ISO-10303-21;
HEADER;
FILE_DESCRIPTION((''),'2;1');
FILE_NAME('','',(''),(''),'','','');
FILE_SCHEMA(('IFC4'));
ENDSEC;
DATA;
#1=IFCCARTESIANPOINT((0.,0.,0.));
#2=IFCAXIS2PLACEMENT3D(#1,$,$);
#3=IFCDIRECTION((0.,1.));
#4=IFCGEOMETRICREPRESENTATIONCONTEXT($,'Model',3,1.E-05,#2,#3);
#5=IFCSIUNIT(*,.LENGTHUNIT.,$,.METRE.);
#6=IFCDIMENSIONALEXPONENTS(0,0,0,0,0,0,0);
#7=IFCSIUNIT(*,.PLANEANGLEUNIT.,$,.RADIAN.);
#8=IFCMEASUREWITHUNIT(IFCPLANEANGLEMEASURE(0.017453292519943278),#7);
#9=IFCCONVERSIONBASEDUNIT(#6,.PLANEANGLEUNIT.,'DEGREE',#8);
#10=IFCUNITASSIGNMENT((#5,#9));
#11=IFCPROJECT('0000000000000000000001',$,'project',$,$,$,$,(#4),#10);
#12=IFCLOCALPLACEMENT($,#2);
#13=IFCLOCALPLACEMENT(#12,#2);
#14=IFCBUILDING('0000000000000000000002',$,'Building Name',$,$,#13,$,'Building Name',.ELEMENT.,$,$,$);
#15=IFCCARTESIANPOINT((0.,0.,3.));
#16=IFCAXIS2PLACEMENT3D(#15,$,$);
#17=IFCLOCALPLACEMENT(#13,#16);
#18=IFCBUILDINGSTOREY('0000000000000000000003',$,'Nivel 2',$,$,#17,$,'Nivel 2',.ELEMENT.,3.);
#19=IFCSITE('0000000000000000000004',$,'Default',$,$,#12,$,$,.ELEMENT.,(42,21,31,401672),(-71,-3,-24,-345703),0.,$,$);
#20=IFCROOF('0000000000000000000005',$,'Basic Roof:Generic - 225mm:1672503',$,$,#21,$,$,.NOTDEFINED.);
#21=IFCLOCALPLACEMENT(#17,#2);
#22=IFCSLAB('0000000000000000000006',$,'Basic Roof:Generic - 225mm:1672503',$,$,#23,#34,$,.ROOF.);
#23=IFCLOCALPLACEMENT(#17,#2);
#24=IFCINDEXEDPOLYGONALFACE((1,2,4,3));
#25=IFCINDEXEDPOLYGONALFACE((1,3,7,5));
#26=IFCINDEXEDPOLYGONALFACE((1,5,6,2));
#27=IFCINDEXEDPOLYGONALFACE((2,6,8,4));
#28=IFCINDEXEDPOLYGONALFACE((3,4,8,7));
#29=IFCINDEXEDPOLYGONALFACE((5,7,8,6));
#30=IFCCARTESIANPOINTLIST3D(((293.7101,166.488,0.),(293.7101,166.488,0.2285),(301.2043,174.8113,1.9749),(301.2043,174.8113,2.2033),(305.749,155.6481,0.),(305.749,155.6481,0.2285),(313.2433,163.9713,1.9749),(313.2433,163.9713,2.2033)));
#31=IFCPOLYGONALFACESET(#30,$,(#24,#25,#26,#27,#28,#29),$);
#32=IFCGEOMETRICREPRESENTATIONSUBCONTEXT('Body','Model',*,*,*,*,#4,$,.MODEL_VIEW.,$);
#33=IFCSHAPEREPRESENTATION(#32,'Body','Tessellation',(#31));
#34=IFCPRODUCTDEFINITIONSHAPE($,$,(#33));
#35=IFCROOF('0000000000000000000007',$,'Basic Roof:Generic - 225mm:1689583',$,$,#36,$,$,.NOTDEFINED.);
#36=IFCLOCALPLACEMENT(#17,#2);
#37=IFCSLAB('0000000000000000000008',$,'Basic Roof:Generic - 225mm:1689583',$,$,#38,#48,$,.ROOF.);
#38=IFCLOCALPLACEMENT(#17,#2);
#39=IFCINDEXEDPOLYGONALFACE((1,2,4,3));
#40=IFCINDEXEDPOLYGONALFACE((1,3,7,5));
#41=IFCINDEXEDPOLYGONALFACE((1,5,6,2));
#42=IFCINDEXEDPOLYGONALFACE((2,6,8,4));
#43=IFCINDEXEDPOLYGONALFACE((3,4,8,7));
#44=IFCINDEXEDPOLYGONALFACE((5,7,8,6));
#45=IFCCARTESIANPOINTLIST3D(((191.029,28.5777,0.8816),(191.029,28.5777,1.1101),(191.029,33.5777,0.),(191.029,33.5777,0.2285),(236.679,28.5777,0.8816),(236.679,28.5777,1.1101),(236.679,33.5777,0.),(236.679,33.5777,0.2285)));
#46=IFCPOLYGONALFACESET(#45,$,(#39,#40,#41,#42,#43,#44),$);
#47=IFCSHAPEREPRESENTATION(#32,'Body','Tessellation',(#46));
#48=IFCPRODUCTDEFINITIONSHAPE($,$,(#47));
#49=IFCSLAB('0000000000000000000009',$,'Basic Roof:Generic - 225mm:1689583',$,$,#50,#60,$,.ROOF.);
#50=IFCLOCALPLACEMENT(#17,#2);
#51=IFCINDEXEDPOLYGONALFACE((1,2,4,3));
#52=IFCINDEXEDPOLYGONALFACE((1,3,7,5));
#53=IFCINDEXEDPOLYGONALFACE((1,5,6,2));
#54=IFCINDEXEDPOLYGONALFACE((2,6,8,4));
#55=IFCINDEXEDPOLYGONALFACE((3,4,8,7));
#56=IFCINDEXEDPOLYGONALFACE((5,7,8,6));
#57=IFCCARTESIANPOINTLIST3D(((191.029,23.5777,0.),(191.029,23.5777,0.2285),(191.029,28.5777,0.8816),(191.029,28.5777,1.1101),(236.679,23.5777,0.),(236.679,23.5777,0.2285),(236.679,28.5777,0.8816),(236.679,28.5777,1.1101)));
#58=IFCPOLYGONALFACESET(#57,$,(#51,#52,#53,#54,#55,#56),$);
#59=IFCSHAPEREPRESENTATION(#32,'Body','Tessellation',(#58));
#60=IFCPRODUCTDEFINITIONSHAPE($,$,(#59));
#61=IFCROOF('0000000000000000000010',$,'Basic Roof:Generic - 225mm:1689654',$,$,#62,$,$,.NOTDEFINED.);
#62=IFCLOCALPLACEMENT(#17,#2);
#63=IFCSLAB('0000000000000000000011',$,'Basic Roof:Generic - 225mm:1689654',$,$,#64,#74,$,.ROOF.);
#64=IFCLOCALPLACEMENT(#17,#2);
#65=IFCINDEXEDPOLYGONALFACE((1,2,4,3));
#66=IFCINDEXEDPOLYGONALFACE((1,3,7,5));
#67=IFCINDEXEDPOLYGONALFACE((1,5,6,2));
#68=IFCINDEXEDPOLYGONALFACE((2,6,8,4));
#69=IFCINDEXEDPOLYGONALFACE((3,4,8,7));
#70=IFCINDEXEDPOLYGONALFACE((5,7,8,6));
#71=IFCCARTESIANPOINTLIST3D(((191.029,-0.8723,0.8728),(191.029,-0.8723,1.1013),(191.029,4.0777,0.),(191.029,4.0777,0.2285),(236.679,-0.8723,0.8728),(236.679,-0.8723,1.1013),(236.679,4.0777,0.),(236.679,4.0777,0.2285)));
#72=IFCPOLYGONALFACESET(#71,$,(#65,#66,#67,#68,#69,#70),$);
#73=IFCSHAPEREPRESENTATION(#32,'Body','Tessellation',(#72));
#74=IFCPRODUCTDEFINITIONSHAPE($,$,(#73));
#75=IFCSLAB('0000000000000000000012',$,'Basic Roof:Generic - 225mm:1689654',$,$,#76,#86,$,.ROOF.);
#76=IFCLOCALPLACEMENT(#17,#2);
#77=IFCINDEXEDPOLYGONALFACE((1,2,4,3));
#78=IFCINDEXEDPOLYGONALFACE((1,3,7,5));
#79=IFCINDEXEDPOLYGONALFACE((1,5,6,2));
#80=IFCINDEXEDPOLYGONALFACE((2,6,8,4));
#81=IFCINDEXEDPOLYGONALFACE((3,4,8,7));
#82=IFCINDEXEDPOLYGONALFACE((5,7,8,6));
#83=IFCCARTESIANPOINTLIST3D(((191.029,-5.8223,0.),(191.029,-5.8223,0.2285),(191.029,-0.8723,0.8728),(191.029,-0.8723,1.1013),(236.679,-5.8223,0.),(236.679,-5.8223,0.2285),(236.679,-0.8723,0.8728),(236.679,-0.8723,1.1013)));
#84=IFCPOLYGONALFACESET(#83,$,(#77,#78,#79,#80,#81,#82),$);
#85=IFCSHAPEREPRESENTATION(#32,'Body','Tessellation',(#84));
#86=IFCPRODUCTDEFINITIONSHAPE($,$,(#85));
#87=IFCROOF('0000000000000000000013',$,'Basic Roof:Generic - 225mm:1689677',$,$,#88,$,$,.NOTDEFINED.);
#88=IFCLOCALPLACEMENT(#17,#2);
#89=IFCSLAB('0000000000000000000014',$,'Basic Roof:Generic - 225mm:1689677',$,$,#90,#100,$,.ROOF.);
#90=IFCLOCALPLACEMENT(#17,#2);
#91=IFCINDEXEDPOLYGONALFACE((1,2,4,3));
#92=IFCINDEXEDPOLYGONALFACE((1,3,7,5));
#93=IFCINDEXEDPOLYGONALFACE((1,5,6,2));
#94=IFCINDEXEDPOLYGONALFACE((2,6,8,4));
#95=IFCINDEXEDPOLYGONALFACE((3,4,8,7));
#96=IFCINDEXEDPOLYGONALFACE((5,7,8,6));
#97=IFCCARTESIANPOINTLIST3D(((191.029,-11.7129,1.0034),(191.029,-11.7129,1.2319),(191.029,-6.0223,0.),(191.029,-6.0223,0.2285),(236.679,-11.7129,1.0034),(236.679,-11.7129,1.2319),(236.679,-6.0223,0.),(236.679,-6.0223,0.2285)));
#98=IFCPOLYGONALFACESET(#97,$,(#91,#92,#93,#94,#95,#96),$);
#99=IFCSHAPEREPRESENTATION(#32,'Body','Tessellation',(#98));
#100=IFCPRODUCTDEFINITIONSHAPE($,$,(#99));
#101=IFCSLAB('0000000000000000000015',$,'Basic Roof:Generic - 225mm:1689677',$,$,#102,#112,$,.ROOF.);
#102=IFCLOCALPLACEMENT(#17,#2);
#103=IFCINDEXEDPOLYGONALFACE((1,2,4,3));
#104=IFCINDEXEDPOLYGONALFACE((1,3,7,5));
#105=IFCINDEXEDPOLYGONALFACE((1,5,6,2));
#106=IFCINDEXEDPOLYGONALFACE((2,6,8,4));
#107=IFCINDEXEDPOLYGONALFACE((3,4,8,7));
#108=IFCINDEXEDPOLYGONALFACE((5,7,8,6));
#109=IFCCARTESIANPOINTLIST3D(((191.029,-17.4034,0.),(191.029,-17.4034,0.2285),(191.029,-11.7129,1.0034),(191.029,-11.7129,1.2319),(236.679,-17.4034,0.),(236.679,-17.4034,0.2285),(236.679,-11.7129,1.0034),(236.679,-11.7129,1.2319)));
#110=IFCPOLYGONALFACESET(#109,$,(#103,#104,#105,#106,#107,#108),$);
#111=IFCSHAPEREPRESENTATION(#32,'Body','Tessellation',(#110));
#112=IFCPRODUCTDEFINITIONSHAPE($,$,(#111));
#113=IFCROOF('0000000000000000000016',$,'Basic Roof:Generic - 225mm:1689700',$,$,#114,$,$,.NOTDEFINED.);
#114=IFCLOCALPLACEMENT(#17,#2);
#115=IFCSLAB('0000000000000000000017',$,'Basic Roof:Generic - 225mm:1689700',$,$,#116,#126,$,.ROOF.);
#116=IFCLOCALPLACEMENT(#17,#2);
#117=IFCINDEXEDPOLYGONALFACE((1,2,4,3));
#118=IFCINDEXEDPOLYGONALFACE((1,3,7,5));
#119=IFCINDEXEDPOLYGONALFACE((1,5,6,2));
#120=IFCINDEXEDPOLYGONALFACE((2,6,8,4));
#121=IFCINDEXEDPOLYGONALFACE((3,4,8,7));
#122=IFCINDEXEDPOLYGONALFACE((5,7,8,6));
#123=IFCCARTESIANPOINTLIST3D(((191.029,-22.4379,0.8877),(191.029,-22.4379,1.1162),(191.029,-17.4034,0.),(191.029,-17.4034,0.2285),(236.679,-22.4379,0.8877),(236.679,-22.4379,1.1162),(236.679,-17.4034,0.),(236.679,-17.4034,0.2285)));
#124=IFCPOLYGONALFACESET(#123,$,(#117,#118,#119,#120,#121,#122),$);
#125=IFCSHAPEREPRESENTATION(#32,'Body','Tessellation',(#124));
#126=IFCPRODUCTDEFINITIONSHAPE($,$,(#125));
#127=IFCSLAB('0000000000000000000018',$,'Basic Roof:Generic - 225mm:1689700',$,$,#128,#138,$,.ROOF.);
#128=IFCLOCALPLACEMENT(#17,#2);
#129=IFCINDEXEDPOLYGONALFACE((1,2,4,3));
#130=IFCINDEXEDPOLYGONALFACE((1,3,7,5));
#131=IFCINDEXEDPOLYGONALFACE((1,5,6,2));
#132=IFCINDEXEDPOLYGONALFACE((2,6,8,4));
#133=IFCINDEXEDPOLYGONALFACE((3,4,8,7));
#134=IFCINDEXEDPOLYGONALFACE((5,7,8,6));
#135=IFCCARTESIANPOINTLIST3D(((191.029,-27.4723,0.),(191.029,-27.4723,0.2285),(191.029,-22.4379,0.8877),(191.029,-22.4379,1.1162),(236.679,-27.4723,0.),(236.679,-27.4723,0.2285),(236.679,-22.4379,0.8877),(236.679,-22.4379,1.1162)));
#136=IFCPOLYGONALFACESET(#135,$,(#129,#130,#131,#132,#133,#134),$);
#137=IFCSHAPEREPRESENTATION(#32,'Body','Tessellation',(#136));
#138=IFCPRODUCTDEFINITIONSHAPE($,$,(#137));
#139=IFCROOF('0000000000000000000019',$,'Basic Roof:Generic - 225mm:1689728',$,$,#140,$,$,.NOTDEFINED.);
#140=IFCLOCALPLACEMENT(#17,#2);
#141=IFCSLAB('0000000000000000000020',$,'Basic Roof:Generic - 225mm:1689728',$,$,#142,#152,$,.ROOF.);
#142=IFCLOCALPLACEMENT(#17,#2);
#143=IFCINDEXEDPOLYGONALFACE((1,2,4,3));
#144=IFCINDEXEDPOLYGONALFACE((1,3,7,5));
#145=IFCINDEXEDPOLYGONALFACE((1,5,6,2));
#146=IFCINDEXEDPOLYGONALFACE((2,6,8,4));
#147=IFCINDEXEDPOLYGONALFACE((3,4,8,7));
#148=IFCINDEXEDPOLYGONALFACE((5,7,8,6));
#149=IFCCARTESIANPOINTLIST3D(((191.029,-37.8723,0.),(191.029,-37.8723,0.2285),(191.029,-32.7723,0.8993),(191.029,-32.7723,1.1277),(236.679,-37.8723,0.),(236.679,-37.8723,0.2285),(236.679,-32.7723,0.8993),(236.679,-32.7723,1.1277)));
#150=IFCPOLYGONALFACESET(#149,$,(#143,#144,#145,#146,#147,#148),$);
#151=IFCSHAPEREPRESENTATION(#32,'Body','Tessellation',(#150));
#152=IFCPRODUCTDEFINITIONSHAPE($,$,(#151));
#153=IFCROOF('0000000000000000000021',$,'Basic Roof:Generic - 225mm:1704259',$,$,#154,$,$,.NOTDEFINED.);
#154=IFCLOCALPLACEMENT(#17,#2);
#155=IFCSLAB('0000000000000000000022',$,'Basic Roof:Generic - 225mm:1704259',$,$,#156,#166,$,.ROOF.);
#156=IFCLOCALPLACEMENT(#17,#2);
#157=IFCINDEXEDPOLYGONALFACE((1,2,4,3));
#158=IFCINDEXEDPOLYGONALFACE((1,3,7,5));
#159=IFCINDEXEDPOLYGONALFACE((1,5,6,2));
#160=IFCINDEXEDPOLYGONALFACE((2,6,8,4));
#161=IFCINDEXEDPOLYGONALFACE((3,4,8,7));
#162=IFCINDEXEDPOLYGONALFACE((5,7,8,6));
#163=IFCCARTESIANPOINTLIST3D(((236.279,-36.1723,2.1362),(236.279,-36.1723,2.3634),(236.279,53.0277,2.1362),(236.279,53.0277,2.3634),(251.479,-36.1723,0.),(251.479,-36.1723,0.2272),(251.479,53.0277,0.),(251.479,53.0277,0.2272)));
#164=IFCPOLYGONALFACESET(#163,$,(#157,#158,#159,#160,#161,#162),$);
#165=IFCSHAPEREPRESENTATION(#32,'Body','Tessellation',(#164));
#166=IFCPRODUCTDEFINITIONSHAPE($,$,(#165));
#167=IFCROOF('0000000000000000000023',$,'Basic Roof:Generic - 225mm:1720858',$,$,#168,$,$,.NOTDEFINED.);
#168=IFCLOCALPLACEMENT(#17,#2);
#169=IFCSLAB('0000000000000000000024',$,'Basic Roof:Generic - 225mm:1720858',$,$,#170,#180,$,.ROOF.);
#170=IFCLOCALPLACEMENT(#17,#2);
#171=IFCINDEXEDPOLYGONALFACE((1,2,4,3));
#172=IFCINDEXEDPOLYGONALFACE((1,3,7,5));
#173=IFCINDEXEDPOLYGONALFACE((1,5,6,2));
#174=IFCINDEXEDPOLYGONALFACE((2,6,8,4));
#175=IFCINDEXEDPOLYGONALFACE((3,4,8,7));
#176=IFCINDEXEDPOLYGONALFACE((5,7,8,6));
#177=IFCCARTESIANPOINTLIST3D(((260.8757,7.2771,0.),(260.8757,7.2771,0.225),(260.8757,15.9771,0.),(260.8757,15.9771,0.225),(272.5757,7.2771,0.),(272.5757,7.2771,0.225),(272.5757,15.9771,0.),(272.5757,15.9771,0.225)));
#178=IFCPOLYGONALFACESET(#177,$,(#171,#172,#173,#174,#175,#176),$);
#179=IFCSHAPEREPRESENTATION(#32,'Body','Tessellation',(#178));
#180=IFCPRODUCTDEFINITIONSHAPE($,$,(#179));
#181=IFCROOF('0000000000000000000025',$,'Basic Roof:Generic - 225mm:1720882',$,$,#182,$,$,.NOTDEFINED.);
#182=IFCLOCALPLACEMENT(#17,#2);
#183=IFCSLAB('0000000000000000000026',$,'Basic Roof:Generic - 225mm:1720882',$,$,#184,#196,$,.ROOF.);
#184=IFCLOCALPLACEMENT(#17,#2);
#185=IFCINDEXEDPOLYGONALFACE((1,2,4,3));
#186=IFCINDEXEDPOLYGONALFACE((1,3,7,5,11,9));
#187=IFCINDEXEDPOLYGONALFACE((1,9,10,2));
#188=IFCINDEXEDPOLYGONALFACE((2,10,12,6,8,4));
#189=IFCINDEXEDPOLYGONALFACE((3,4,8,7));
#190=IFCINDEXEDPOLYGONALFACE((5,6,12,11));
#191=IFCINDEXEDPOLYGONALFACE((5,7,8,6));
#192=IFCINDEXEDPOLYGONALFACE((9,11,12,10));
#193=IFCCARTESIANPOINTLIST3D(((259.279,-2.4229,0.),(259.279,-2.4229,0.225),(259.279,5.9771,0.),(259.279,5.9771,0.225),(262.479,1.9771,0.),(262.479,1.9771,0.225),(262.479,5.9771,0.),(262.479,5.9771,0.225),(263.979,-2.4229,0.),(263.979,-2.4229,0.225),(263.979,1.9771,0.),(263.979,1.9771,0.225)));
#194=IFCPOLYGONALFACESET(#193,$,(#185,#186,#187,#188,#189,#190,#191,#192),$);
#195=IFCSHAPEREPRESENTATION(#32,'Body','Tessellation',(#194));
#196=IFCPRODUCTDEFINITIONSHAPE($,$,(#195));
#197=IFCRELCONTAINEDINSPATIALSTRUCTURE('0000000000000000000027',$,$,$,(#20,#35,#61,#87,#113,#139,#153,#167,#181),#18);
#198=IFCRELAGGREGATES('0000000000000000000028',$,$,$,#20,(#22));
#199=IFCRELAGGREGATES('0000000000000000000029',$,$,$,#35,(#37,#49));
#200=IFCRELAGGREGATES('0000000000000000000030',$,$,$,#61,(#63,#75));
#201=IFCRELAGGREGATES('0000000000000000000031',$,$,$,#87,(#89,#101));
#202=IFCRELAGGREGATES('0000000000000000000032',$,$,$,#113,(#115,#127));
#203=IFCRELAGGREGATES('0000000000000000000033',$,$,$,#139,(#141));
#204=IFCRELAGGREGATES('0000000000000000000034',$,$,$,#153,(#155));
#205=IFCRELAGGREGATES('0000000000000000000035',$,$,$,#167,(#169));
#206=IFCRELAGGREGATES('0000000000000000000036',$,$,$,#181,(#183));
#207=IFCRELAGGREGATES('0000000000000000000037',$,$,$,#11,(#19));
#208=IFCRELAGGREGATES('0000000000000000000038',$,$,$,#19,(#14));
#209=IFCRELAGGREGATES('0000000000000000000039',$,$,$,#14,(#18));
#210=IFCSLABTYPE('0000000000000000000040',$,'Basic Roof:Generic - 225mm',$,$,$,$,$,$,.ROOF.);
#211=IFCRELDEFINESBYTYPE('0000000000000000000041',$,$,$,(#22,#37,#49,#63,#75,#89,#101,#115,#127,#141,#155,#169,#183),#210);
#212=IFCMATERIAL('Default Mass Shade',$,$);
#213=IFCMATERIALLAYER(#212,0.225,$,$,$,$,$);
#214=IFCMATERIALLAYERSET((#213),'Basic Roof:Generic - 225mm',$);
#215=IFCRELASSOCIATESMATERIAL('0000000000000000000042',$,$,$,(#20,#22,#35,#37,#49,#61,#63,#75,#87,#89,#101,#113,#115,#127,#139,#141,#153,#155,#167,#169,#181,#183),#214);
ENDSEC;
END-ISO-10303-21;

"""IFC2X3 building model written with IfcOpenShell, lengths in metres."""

from ifc_helpers import new_model, entity, si_unit, converted_unit, direction, frame, frame_2d, origin, place, context, subcontext, project, spatial, polyline, rectangle, outline, extrude, material, layer, layer_set, type_object, element, aggregate, save


model = new_model("IFC2X3")

# Units and contexts
model_context = context("Model", 3, precision=1e-05, world=origin(), true_north=direction((0.0, 1.0)))
body_context = subcontext(model_context, "Body", "Model", "MODEL_VIEW")
ifc_project = project(units=[si_unit("LENGTHUNIT", "METRE"), converted_unit("PLANEANGLEUNIT", "DEGREE", entity("IfcPlaneAngleMeasure", 0.017453292519943278), si_unit("PLANEANGLEUNIT", "RADIAN"), dimensions=[0, 0, 0, 0, 0, 0, 0])], contexts=[model_context])

# Site, building, storey
site_placement = place(None, origin())
site = spatial("IfcSite", under=ifc_project, at=site_placement, Name="Default", CompositionType="ELEMENT", RefLatitude=(42, 21, 31, 401672), RefLongitude=(-71, -3, -24, -345703), RefElevation=0.0)
building_placement = place(site_placement, origin())
building = spatial("IfcBuilding", under=site, at=building_placement, Name="Building Name", LongName="Building Name", CompositionType="ELEMENT")
storey_placement = place(building_placement, frame((0.0, 0.0, 3.0)))
storey = spatial("IfcBuildingStorey", under=building, at=storey_placement, Name="Nivel 2", LongName="Nivel 2", CompositionType="ELEMENT", Elevation=3.0)

# Roof, slab
ifc_material_1 = material(Name="Default Mass Shade")
ifc_layer_1 = layer(ifc_material_1, 0.225)
ifc_layer_set_1 = layer_set([ifc_layer_1], Name="Basic Roof:Generic - 225mm")
roof_1_placement = place(storey_placement, frame((293.7101, 155.6481, 0.0)))
roof_1 = element("IfcRoof", 1, at=roof_1_placement, inside=storey, material=ifc_layer_set_1, Name="Basic Roof:Generic - 225mm:1672503", ShapeType="NOTDEFINED")
slab_type = type_object("IfcSlabType", Name="Basic Roof:Generic - 225mm", PredefinedType="ROOF")
slab_1_placement = place(roof_1_placement, origin())
slab_1 = element("IfcSlab", 2, at=slab_1_placement, type_object=slab_type, material=ifc_layer_set_1, Name="Basic Roof:Generic - 225mm:1672503", PredefinedType="ROOF", context=body_context, shape_type="SweptSolid", body=[
    extrude(rectangle(XDim=16.2, YDim=11.3728, at=frame_2d((0.0, 0.0), x_axis=(-0.748213, 0.663459))), frame((9.7666, 9.5816, 0.9874), z_axis=(-0.116193, -0.129046, 0.984808), x_axis=(0.993227, -0.015097, 0.115208)), (0.115208, 0.129926, 0.984808), 0.2285),
])
aggregate(roof_1, [slab_1])

# Roofs, slabs
roof_2_placement = place(storey_placement, frame((191.029, 23.5777, 0.0)))
roof_2 = element("IfcRoof", 3, at=roof_2_placement, inside=storey, material=ifc_layer_set_1, Name="Basic Roof:Generic - 225mm:1689583", ShapeType="NOTDEFINED")
slab_2_placement = place(roof_2_placement, origin())
slab_2 = element("IfcSlab", 4, at=slab_2_placement, type_object=slab_type, material=ifc_layer_set_1, Name="Basic Roof:Generic - 225mm:1689583", PredefinedType="ROOF", context=body_context, shape_type="SweptSolid", body=[
    extrude(rectangle(XDim=45.65, YDim=5.0771, at=frame_2d((0.0, 0.0), x_axis=(1.0, 0.0))), frame((22.825, 7.5, 0.4408), z_axis=(0.0, 0.173648, 0.984808), x_axis=(1.0, 0.0, 0.0)), (0.0, -0.173648, 0.984808), 0.2285),
])
slab_3_placement = place(roof_2_placement, origin())
slab_3 = element("IfcSlab", 5, at=slab_3_placement, type_object=slab_type, material=ifc_layer_set_1, Name="Basic Roof:Generic - 225mm:1689583", PredefinedType="ROOF", context=body_context, shape_type="SweptSolid", body=[
    extrude(rectangle(XDim=5.0771, YDim=45.65, at=frame_2d((0.0, 0.0), x_axis=(0.0, 1.0))), frame((22.825, 2.5, 0.4408), z_axis=(0.0, -0.173648, 0.984808), x_axis=(1.0, 0.0, 0.0)), (0.0, 0.173648, 0.984808), 0.2285),
])
aggregate(roof_2, [slab_2, slab_3])
roof_3_placement = place(storey_placement, frame((191.029, -5.8223, 0.0)))
roof_3 = element("IfcRoof", 6, at=roof_3_placement, inside=storey, material=ifc_layer_set_1, Name="Basic Roof:Generic - 225mm:1689654", ShapeType="NOTDEFINED")
slab_4_placement = place(roof_3_placement, origin())
slab_4 = element("IfcSlab", 7, at=slab_4_placement, type_object=slab_type, material=ifc_layer_set_1, Name="Basic Roof:Generic - 225mm:1689654", PredefinedType="ROOF", context=body_context, shape_type="SweptSolid", body=[
    extrude(rectangle(XDim=45.65, YDim=5.0264, at=frame_2d((0.0, 0.0), x_axis=(1.0, 0.0))), frame((22.825, 7.425, 0.4364), z_axis=(0.0, 0.173648, 0.984808), x_axis=(1.0, 0.0, 0.0)), (0.0, -0.173648, 0.984808), 0.2285),
])
slab_5_placement = place(roof_3_placement, origin())
slab_5 = element("IfcSlab", 8, at=slab_5_placement, type_object=slab_type, material=ifc_layer_set_1, Name="Basic Roof:Generic - 225mm:1689654", PredefinedType="ROOF", context=body_context, shape_type="SweptSolid", body=[
    extrude(rectangle(XDim=5.0264, YDim=45.65, at=frame_2d((0.0, 0.0), x_axis=(0.0, 1.0))), frame((22.825, 2.475, 0.4364), z_axis=(0.0, -0.173648, 0.984808), x_axis=(1.0, 0.0, 0.0)), (0.0, 0.173648, 0.984808), 0.2285),
])
aggregate(roof_3, [slab_4, slab_5])
roof_4_placement = place(storey_placement, frame((191.029, -17.4034, 0.0)))
roof_4 = element("IfcRoof", 9, at=roof_4_placement, inside=storey, material=ifc_layer_set_1, Name="Basic Roof:Generic - 225mm:1689677", ShapeType="NOTDEFINED")
slab_6_placement = place(roof_4_placement, origin())
slab_6 = element("IfcSlab", 10, at=slab_6_placement, type_object=slab_type, material=ifc_layer_set_1, Name="Basic Roof:Generic - 225mm:1689677", PredefinedType="ROOF", context=body_context, shape_type="SweptSolid", body=[
    extrude(rectangle(XDim=45.65, YDim=5.7783, at=frame_2d((0.0, 0.0), x_axis=(1.0, 0.0))), frame((22.825, 8.5358, 0.5017), z_axis=(0.0, 0.173648, 0.984808), x_axis=(1.0, 0.0, 0.0)), (0.0, -0.173648, 0.984808), 0.2285),
])
slab_7_placement = place(roof_4_placement, origin())
slab_7 = element("IfcSlab", 11, at=slab_7_placement, type_object=slab_type, material=ifc_layer_set_1, Name="Basic Roof:Generic - 225mm:1689677", PredefinedType="ROOF", context=body_context, shape_type="SweptSolid", body=[
    extrude(rectangle(XDim=5.7783, YDim=45.65, at=frame_2d((0.0, 0.0), x_axis=(0.0, 1.0))), frame((22.825, 2.8453, 0.5017), z_axis=(0.0, -0.173648, 0.984808), x_axis=(1.0, 0.0, 0.0)), (0.0, 0.173648, 0.984808), 0.2285),
])
aggregate(roof_4, [slab_6, slab_7])
roof_5_placement = place(storey_placement, frame((191.029, -27.4723, 0.0)))
roof_5 = element("IfcRoof", 12, at=roof_5_placement, inside=storey, material=ifc_layer_set_1, Name="Basic Roof:Generic - 225mm:1689700", ShapeType="NOTDEFINED")
slab_8_placement = place(roof_5_placement, origin())
slab_8 = element("IfcSlab", 13, at=slab_8_placement, type_object=slab_type, material=ifc_layer_set_1, Name="Basic Roof:Generic - 225mm:1689700", PredefinedType="ROOF", context=body_context, shape_type="SweptSolid", body=[
    extrude(rectangle(XDim=45.65, YDim=5.1121, at=frame_2d((0.0, 0.0), x_axis=(1.0, 0.0))), frame((22.825, 7.5517, 0.4439), z_axis=(0.0, 0.173648, 0.984808), x_axis=(1.0, 0.0, 0.0)), (0.0, -0.173648, 0.984808), 0.2285),
])
slab_9_placement = place(roof_5_placement, origin())
slab_9 = element("IfcSlab", 14, at=slab_9_placement, type_object=slab_type, material=ifc_layer_set_1, Name="Basic Roof:Generic - 225mm:1689700", PredefinedType="ROOF", context=body_context, shape_type="SweptSolid", body=[
    extrude(rectangle(XDim=5.1121, YDim=45.65, at=frame_2d((0.0, 0.0), x_axis=(0.0, 1.0))), frame((22.825, 2.5172, 0.4439), z_axis=(0.0, -0.173648, 0.984808), x_axis=(1.0, 0.0, 0.0)), (0.0, 0.173648, 0.984808), 0.2285),
])
aggregate(roof_5, [slab_8, slab_9])

# Roofs, slabs
roof_6_placement = place(storey_placement, frame((191.029, -37.8723, 0.0)))
roof_6 = element("IfcRoof", 15, at=roof_6_placement, inside=storey, material=ifc_layer_set_1, Name="Basic Roof:Generic - 225mm:1689728", ShapeType="NOTDEFINED")
slab_10_placement = place(roof_6_placement, origin())
slab_10 = element("IfcSlab", 16, at=slab_10_placement, type_object=slab_type, material=ifc_layer_set_1, Name="Basic Roof:Generic - 225mm:1689728", PredefinedType="ROOF", context=body_context, shape_type="SweptSolid", body=[
    extrude(rectangle(XDim=5.1787, YDim=45.65, at=frame_2d((0.0, 0.0), x_axis=(0.0, 1.0))), frame((22.825, 2.55, 0.4496), z_axis=(0.0, -0.173648, 0.984808), x_axis=(1.0, 0.0, 0.0)), (0.0, 0.173648, 0.984808), 0.2285),
])
aggregate(roof_6, [slab_10])
roof_7_placement = place(storey_placement, frame((236.279, -36.1723, 0.0)))
roof_7 = element("IfcRoof", 17, at=roof_7_placement, inside=storey, material=ifc_layer_set_1, Name="Basic Roof:Generic - 225mm:1704259", ShapeType="NOTDEFINED")
slab_11_placement = place(roof_7_placement, origin())
slab_11 = element("IfcSlab", 18, at=slab_11_placement, type_object=slab_type, material=ifc_layer_set_1, Name="Basic Roof:Generic - 225mm:1704259", PredefinedType="ROOF", context=body_context, shape_type="SweptSolid", body=[
    extrude(rectangle(XDim=89.2, YDim=15.3494, at=frame_2d((0.0, 0.0), x_axis=(0.0, 1.0))), frame((7.6, 44.6, 1.0681), z_axis=(0.139173, 0.0, 0.990268), x_axis=(0.990268, 0.0, -0.139173)), (-0.139173, 0.0, 0.990268), 0.2272),
])
aggregate(roof_7, [slab_11])
roof_8_placement = place(storey_placement, frame((260.8757, 7.2771, 0.0)))
roof_8 = element("IfcRoof", 19, at=roof_8_placement, inside=storey, material=ifc_layer_set_1, Name="Basic Roof:Generic - 225mm:1720858", ShapeType="NOTDEFINED")
slab_12_placement = place(roof_8_placement, origin())
slab_12 = element("IfcSlab", 20, at=slab_12_placement, type_object=slab_type, material=ifc_layer_set_1, Name="Basic Roof:Generic - 225mm:1720858", PredefinedType="ROOF", context=body_context, shape_type="SweptSolid", body=[
    extrude(rectangle(XDim=11.7, YDim=8.7, at=frame_2d((0.0, 0.0), x_axis=(1.0, 0.0))), frame((5.85, 4.35, 0.0)), (0.0, 0.0, 1.0), 0.225),
])
aggregate(roof_8, [slab_12])
roof_9_placement = place(storey_placement, frame((259.279, -2.4229, 0.0)))
roof_9 = element("IfcRoof", 21, at=roof_9_placement, inside=storey, material=ifc_layer_set_1, Name="Basic Roof:Generic - 225mm:1720882", ShapeType="NOTDEFINED")
slab_13_placement = place(roof_9_placement, origin())
slab_13 = element("IfcSlab", 22, at=slab_13_placement, type_object=slab_type, material=ifc_layer_set_1, Name="Basic Roof:Generic - 225mm:1720882", PredefinedType="ROOF", context=body_context, shape_type="SweptSolid", body=[
    extrude(outline(polyline([(-2.35, 4.2), (-2.35, -4.2), (2.35, -4.2), (2.35, 0.2), (0.85, 0.2), (0.85, 4.2), (-2.35, 4.2)])), frame((2.35, 4.2, 0.0)), (0.0, 0.0, 1.0), 0.225),
])
aggregate(roof_9, [slab_13])

save(model, "model.ifc")
